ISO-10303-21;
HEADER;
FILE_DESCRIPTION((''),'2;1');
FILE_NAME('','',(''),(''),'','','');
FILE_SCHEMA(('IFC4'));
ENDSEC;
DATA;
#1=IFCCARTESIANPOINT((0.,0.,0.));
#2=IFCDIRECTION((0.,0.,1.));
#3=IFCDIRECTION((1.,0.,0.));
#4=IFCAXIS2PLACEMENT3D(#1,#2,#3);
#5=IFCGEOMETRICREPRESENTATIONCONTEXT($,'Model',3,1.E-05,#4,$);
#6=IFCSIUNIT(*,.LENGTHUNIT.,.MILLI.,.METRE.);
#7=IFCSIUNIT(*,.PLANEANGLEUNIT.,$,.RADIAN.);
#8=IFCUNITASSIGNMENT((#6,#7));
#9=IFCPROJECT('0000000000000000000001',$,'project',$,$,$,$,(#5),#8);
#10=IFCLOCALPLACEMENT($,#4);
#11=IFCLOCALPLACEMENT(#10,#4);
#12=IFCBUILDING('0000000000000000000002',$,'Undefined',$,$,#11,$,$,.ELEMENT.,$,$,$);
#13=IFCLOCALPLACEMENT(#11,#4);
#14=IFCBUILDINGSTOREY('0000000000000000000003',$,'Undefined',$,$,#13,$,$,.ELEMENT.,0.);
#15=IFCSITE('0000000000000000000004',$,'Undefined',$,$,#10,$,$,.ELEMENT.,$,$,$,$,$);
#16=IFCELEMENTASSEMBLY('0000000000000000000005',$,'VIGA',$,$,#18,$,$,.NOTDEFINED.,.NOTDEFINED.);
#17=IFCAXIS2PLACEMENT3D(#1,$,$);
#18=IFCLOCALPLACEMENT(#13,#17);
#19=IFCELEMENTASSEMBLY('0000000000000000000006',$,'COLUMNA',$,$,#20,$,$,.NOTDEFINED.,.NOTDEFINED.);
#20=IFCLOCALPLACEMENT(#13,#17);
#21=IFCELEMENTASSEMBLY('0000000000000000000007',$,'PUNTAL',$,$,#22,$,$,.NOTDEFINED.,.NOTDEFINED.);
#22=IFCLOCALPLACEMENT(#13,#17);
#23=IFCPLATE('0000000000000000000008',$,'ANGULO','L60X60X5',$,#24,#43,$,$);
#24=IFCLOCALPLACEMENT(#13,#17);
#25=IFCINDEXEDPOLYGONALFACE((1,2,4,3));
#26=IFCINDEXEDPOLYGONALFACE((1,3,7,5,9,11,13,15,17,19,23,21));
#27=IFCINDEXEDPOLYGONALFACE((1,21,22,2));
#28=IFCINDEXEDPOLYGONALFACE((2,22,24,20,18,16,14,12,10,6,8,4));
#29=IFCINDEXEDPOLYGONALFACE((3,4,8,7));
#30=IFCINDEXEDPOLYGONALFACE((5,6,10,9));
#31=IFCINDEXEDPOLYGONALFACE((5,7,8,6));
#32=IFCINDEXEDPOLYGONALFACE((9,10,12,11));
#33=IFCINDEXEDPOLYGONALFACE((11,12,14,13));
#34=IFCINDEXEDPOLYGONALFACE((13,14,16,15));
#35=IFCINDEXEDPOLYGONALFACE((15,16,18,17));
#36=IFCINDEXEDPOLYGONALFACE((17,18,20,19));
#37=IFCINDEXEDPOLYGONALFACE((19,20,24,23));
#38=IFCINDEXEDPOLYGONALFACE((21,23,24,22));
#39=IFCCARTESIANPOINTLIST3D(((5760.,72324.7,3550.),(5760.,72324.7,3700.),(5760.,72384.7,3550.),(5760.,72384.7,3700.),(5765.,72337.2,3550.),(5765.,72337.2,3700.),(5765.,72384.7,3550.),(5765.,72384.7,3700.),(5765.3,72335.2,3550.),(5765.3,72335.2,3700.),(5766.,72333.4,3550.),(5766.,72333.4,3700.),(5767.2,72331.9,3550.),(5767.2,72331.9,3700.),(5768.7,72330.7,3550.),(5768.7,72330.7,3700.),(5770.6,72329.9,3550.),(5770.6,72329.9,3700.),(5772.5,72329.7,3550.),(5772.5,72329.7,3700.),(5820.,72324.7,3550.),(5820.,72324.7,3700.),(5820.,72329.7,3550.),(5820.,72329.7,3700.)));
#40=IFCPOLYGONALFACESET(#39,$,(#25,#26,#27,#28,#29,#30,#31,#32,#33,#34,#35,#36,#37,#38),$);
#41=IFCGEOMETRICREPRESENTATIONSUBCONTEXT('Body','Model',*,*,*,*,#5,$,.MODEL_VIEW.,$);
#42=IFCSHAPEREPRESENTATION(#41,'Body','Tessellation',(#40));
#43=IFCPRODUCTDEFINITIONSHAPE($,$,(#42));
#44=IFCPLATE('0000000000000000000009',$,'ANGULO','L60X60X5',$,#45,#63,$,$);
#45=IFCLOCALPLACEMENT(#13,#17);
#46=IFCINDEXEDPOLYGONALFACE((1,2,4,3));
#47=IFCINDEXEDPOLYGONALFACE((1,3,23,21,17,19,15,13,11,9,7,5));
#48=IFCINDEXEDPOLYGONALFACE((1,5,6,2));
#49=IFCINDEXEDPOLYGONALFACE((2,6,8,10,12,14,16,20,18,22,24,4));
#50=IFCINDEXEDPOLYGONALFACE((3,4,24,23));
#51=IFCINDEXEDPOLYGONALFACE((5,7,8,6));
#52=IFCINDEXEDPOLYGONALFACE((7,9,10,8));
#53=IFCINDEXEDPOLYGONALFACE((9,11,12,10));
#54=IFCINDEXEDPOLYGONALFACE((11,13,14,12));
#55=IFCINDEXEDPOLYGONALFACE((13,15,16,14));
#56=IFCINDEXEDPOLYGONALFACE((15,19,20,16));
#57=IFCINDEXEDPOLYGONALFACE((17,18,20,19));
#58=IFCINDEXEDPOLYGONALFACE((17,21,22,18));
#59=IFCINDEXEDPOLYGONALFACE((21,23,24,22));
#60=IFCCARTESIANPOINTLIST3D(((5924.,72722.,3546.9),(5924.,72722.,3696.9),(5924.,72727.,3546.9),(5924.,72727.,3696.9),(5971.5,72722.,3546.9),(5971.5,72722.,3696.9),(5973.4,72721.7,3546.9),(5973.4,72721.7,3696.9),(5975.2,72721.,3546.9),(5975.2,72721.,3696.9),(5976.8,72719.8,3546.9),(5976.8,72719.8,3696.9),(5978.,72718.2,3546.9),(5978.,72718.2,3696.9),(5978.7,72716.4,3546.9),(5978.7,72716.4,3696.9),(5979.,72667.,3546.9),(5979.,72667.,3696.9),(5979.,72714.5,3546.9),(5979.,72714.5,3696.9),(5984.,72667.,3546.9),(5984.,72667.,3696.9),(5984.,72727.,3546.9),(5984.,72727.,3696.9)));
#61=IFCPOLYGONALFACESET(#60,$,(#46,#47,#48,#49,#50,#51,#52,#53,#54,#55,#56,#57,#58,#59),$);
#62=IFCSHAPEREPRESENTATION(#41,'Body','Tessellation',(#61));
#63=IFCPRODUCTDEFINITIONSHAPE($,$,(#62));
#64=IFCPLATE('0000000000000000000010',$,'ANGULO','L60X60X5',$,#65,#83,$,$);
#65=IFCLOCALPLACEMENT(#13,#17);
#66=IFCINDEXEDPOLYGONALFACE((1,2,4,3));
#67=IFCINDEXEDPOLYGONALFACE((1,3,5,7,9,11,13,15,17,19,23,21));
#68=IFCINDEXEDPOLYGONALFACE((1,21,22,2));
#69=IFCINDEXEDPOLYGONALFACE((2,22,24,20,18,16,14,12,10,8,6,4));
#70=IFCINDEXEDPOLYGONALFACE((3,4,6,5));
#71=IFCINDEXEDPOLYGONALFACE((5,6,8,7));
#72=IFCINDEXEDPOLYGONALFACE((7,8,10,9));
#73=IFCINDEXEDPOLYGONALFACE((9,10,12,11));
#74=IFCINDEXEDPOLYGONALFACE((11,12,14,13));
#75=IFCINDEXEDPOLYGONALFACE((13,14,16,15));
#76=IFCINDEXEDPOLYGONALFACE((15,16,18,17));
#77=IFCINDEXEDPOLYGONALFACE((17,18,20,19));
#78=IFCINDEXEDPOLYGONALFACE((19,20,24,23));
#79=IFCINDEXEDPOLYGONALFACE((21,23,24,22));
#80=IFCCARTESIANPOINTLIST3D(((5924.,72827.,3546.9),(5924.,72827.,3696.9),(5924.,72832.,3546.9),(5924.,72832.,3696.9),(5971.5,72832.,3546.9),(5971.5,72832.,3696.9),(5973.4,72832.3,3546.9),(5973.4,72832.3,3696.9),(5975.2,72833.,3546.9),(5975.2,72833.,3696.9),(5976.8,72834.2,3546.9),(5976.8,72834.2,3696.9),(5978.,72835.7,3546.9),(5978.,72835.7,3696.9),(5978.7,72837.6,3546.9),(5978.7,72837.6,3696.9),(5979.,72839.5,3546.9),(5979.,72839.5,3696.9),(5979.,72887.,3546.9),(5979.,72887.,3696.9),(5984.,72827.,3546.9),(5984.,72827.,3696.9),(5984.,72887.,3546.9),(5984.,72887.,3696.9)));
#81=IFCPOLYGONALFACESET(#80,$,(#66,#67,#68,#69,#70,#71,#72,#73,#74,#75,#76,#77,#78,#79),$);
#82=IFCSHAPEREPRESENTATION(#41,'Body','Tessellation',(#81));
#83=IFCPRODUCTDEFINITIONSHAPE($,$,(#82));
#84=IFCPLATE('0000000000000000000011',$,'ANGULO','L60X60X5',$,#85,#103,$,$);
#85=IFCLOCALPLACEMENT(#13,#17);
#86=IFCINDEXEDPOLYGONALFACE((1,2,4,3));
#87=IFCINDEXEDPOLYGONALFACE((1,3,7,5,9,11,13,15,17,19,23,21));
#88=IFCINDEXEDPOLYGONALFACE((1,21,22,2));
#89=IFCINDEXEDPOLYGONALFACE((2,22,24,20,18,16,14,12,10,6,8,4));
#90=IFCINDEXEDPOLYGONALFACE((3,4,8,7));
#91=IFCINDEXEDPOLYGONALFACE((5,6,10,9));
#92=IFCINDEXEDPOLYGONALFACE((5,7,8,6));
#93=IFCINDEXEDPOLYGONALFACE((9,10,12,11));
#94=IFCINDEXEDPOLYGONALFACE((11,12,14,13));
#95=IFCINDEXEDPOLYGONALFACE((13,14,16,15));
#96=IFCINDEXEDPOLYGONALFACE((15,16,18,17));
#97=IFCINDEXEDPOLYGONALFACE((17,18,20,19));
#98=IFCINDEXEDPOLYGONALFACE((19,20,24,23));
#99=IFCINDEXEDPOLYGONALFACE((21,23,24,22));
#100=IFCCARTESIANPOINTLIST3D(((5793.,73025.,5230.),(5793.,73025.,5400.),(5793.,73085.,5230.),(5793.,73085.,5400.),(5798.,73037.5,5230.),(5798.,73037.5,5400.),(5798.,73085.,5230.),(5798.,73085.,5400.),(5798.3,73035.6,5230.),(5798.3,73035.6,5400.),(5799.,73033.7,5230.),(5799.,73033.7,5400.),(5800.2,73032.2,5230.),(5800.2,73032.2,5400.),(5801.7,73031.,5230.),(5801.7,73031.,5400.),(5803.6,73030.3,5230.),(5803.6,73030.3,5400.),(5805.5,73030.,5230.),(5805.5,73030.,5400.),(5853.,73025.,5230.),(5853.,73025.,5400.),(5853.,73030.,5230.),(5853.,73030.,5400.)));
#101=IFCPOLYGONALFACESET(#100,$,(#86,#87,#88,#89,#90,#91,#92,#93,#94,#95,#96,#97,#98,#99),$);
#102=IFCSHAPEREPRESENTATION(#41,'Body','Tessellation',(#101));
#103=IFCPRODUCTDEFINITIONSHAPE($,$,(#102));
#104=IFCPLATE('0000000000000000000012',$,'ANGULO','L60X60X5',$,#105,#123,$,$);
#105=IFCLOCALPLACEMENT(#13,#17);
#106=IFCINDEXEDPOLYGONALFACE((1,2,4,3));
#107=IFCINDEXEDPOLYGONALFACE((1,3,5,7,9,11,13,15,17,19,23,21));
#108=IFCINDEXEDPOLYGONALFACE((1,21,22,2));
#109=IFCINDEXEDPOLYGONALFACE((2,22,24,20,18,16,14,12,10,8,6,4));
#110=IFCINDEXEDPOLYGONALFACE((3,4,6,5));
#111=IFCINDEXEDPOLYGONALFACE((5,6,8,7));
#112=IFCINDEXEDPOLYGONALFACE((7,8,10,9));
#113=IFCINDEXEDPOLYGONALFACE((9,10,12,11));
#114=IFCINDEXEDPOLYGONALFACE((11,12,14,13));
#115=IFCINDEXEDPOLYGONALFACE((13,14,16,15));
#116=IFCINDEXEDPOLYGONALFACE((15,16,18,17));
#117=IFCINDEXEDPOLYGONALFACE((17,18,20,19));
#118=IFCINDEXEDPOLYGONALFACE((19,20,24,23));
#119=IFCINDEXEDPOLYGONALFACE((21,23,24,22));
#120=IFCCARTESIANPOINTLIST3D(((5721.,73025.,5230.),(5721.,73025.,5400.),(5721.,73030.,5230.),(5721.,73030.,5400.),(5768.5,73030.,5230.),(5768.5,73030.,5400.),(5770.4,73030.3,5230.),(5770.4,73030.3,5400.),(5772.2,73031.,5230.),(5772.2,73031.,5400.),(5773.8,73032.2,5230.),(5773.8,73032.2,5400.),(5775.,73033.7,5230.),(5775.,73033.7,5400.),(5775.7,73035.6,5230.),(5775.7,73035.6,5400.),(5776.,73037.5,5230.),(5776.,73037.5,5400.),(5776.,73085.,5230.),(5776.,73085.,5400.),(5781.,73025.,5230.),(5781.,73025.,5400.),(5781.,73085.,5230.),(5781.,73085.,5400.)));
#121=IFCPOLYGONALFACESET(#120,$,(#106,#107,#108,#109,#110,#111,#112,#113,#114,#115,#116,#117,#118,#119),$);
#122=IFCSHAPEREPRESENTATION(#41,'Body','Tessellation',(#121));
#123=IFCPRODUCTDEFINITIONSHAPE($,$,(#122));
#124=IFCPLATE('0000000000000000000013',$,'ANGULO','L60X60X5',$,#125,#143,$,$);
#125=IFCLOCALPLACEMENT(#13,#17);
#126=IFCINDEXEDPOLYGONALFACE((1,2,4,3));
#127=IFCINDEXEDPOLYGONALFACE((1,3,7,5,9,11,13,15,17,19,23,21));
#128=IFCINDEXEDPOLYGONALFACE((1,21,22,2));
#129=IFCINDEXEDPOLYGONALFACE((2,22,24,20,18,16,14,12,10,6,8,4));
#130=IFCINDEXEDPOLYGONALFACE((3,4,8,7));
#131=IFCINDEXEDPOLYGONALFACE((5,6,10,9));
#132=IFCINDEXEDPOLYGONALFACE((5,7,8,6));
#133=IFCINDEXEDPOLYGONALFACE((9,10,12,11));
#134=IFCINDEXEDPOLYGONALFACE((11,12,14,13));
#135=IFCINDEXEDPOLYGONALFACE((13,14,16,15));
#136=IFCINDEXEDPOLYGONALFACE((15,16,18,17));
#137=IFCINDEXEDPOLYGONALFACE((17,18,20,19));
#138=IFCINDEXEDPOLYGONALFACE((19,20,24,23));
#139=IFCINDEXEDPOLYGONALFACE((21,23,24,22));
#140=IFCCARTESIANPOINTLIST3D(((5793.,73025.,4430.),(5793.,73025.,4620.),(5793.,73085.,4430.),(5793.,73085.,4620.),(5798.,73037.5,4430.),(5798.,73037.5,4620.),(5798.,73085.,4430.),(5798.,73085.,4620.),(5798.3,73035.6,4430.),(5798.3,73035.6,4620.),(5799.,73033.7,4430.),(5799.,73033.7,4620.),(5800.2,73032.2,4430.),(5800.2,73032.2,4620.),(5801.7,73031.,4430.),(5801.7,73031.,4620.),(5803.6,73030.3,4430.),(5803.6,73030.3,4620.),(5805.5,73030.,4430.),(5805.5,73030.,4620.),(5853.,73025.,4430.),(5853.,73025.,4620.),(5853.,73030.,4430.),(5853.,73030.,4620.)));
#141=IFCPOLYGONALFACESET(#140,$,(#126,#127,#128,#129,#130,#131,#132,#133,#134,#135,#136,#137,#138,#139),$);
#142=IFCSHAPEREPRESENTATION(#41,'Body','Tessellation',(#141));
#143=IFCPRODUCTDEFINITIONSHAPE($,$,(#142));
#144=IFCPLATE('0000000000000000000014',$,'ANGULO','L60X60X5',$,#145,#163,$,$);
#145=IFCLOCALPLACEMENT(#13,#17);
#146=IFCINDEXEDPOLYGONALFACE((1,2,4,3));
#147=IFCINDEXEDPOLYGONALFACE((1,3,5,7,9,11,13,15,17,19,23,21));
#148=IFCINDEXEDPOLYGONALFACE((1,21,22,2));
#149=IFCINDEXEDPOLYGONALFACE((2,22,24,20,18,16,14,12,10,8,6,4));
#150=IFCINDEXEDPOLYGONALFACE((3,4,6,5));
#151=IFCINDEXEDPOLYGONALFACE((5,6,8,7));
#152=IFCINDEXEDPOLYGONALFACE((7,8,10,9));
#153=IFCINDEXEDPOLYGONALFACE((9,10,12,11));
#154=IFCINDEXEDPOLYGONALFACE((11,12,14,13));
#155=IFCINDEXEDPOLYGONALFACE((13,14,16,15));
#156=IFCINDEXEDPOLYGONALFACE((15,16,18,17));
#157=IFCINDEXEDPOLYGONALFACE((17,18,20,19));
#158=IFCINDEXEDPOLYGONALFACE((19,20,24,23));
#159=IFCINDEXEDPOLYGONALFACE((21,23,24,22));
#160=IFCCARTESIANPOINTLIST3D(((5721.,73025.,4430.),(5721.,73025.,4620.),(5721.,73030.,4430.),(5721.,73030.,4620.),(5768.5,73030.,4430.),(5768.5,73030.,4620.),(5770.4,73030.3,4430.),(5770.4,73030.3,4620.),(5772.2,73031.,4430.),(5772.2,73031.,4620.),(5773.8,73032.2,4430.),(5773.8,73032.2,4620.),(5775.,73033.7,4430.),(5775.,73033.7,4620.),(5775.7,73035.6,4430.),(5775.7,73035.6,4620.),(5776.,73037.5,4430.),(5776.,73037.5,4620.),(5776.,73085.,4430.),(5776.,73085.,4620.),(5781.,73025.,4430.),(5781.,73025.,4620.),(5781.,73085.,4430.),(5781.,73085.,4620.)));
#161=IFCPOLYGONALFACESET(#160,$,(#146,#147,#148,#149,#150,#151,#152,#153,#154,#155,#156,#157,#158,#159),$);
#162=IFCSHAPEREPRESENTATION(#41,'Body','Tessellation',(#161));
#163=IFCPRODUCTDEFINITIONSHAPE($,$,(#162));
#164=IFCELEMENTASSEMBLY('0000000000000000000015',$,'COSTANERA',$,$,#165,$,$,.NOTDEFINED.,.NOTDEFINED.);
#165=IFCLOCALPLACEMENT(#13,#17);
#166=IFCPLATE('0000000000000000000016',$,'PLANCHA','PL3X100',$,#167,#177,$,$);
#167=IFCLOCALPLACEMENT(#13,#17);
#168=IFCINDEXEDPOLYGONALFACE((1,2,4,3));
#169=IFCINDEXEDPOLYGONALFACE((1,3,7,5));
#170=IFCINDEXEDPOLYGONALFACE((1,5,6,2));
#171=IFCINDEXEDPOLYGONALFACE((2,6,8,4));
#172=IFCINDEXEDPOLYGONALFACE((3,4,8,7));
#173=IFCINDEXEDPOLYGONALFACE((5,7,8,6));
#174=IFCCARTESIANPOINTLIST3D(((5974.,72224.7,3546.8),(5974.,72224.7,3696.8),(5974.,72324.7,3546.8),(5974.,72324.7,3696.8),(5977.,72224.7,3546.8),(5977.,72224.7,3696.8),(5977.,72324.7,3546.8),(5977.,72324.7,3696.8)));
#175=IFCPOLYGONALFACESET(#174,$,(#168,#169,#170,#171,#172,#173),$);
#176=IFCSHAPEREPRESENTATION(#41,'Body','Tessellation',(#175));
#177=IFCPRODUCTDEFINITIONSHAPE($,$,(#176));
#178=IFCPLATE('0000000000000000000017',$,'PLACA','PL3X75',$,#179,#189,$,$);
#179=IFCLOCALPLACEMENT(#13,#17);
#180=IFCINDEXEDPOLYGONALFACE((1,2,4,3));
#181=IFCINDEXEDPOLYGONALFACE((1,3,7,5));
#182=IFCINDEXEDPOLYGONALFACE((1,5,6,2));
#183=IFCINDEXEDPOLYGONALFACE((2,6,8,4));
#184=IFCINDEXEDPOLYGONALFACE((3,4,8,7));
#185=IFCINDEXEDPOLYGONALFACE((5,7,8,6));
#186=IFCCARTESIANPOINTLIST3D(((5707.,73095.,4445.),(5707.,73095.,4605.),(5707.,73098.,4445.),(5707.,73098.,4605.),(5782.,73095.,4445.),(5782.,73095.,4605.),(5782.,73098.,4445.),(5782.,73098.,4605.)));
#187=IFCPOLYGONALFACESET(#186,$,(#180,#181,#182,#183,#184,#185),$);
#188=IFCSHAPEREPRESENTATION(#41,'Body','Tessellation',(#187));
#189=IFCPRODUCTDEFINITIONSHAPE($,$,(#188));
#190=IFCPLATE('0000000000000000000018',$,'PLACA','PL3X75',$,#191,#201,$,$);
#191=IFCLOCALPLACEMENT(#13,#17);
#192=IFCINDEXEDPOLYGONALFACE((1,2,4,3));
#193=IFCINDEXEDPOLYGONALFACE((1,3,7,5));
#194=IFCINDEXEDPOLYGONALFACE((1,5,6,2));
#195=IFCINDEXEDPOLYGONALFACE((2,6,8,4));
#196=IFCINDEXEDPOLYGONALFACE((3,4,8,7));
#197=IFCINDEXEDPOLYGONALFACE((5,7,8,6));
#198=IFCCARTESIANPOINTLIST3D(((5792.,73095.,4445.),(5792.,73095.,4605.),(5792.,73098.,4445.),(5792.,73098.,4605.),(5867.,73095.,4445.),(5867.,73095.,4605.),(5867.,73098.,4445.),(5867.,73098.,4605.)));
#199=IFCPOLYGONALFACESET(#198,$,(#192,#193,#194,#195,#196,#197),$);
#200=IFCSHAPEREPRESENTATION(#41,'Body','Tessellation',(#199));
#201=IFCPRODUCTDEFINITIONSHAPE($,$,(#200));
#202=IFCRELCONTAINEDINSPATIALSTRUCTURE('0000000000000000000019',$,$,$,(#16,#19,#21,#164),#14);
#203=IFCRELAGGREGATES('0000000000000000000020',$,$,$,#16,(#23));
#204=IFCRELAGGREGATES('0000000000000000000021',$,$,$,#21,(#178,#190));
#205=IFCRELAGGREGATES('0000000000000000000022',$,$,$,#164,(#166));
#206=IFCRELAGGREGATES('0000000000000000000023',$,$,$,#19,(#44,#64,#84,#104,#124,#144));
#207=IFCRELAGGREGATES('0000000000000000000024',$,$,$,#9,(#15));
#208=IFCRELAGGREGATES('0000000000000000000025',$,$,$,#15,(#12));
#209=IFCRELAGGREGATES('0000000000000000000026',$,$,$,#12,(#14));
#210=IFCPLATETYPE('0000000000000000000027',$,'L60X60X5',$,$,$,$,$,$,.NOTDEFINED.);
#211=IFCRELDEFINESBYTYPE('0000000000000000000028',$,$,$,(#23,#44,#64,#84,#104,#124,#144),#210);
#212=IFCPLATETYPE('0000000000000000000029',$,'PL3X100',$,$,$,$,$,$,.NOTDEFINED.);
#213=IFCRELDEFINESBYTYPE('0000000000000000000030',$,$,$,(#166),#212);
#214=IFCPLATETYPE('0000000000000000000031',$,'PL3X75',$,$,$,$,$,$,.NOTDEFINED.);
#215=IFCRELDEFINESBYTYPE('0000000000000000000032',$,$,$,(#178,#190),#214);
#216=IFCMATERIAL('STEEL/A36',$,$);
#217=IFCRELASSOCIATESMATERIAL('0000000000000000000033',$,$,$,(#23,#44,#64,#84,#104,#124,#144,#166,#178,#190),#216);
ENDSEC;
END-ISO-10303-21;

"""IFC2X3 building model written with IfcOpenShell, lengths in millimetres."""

from ifc_helpers import new_model, si_unit, frame, origin_with_axes, origin_2d_with_axis, place, context, subcontext, project, spatial, polyline, l_section, outline, extrude, material, type_object, element, aggregate, save


model = new_model("IFC2X3")

# Units and contexts
model_context = context("Model", 3, precision=1e-05, world=origin_with_axes())
body_context = subcontext(model_context, "Body", "Model", "MODEL_VIEW")
ifc_project = project(units=[si_unit("LENGTHUNIT", "METRE", prefix="MILLI"), si_unit("PLANEANGLEUNIT", "RADIAN")], contexts=[model_context])

# Site, building, storey
site_placement = place(None, origin_with_axes())
site = spatial("IfcSite", under=ifc_project, at=site_placement, Name="Undefined", CompositionType="ELEMENT")
building_placement = place(site_placement, origin_with_axes())
building = spatial("IfcBuilding", under=site, at=building_placement, Name="Undefined", CompositionType="ELEMENT")
storey_placement = place(building_placement, origin_with_axes())
storey = spatial("IfcBuildingStorey", under=building, at=storey_placement, Name="Undefined", CompositionType="ELEMENT", Elevation=0.0)

# Element assemblies
assembly_1_placement = place(storey_placement, origin_with_axes())
assembly_1 = element("IfcElementAssembly", 1, at=assembly_1_placement, inside=storey, Name="VIGA", AssemblyPlace="NOTDEFINED", PredefinedType="NOTDEFINED")
ifc_material_1 = material(Name="STEEL/A36")
assembly_2_placement = place(storey_placement, origin_with_axes())
assembly_2 = element("IfcElementAssembly", 2, at=assembly_2_placement, inside=storey, Name="COLUMNA", AssemblyPlace="NOTDEFINED", PredefinedType="NOTDEFINED")
assembly_3_placement = place(storey_placement, origin_with_axes())
assembly_3 = element("IfcElementAssembly", 3, at=assembly_3_placement, inside=storey, Name="PUNTAL", AssemblyPlace="NOTDEFINED", PredefinedType="NOTDEFINED")

# Plates
plate_type_1 = type_object("IfcPlateType", Name="L60X60X5", PredefinedType="NOTDEFINED")
plate_1_placement = place(assembly_1_placement, frame((5790.0, 72354.7, 3700.0), z_axis=(0.0, 1.0, 0.0), x_axis=(0.0, 0.0, -1.0)))
plate_1 = element("IfcPlate", 4, at=plate_1_placement, type_object=plate_type_1, material=ifc_material_1, Name="ANGULO", Description="L60X60X5", context=body_context, shape_type="SweptSolid", body=[
    extrude(l_section(Depth=60.0, Width=60.0, Thickness=5.0, FilletRadius=7.5, at=origin_2d_with_axis()), frame((150.0, 0.0, 0.0), z_axis=(-1.0, 0.0, 0.0), x_axis=(0.0, -1.0, 0.0)), (0.0, 0.0, 1.0), 150.0),
])
aggregate(assembly_1, [plate_1])
plate_2_placement = place(assembly_2_placement, frame((5954.0, 72697.0, 3546.9), z_axis=(-1.0, 0.0, 0.0), x_axis=(0.0, 0.0, 1.0)))
plate_2 = element("IfcPlate", 5, at=plate_2_placement, type_object=plate_type_1, material=ifc_material_1, Name="ANGULO", Description="L60X60X5", context=body_context, shape_type="SweptSolid", body=[
    extrude(l_section(Depth=60.0, Width=60.0, Thickness=5.0, FilletRadius=7.5, at=origin_2d_with_axis()), frame((150.0, 0.0, 0.0), z_axis=(-1.0, 0.0, 0.0), x_axis=(0.0, -1.0, 0.0)), (0.0, 0.0, 1.0), 150.0),
])
plate_3_placement = place(assembly_2_placement, frame((5954.0, 72857.0, 3696.9), z_axis=(-1.0, 0.0, 0.0), x_axis=(0.0, 0.0, -1.0)))
plate_3 = element("IfcPlate", 6, at=plate_3_placement, type_object=plate_type_1, material=ifc_material_1, Name="ANGULO", Description="L60X60X5", context=body_context, shape_type="SweptSolid", body=[
    extrude(l_section(Depth=60.0, Width=60.0, Thickness=5.0, FilletRadius=7.5, at=origin_2d_with_axis()), frame((150.0, 0.0, 0.0), z_axis=(-1.0, 0.0, 0.0), x_axis=(0.0, -1.0, 0.0)), (0.0, 0.0, 1.0), 150.0),
])
plate_4_placement = place(assembly_2_placement, frame((5823.0, 73055.0, 5230.0), z_axis=(1.0, 0.0, 0.0), x_axis=(0.0, 0.0, 1.0)))
plate_4 = element("IfcPlate", 7, at=plate_4_placement, type_object=plate_type_1, material=ifc_material_1, Name="ANGULO", Description="L60X60X5", context=body_context, shape_type="SweptSolid", body=[
    extrude(l_section(Depth=60.0, Width=60.0, Thickness=5.0, FilletRadius=7.5, at=origin_2d_with_axis()), frame((170.0, 0.0, 0.0), z_axis=(-1.0, 0.0, 0.0), x_axis=(0.0, -1.0, 0.0)), (0.0, 0.0, 1.0), 170.0),
])
plate_5_placement = place(assembly_2_placement, frame((5751.0, 73055.0, 5400.0), z_axis=(-1.0, 0.0, 0.0), x_axis=(0.0, 0.0, -1.0)))
plate_5 = element("IfcPlate", 8, at=plate_5_placement, type_object=plate_type_1, material=ifc_material_1, Name="ANGULO", Description="L60X60X5", context=body_context, shape_type="SweptSolid", body=[
    extrude(l_section(Depth=60.0, Width=60.0, Thickness=5.0, FilletRadius=7.5, at=origin_2d_with_axis()), frame((170.0, 0.0, 0.0), z_axis=(-1.0, 0.0, 0.0), x_axis=(0.0, -1.0, 0.0)), (0.0, 0.0, 1.0), 170.0),
])
plate_6_placement = place(assembly_2_placement, frame((5823.0, 73055.0, 4430.0), z_axis=(1.0, 0.0, 0.0), x_axis=(0.0, 0.0, 1.0)))
plate_6 = element("IfcPlate", 9, at=plate_6_placement, type_object=plate_type_1, material=ifc_material_1, Name="ANGULO", Description="L60X60X5", context=body_context, shape_type="SweptSolid", body=[
    extrude(l_section(Depth=60.0, Width=60.0, Thickness=5.0, FilletRadius=7.5, at=origin_2d_with_axis()), frame((190.0, 0.0, 0.0), z_axis=(-1.0, 0.0, 0.0), x_axis=(0.0, -1.0, 0.0)), (0.0, 0.0, 1.0), 190.0),
])
plate_7_placement = place(assembly_2_placement, frame((5751.0, 73055.0, 4620.0), z_axis=(-1.0, 0.0, 0.0), x_axis=(0.0, 0.0, -1.0)))
plate_7 = element("IfcPlate", 10, at=plate_7_placement, type_object=plate_type_1, material=ifc_material_1, Name="ANGULO", Description="L60X60X5", context=body_context, shape_type="SweptSolid", body=[
    extrude(l_section(Depth=60.0, Width=60.0, Thickness=5.0, FilletRadius=7.5, at=origin_2d_with_axis()), frame((190.0, 0.0, 0.0), z_axis=(-1.0, 0.0, 0.0), x_axis=(0.0, -1.0, 0.0)), (0.0, 0.0, 1.0), 190.0),
])

# Element assembly, plate
assembly_4_placement = place(storey_placement, origin_with_axes())
assembly_4 = element("IfcElementAssembly", 11, at=assembly_4_placement, inside=storey, Name="COSTANERA", AssemblyPlace="NOTDEFINED", PredefinedType="NOTDEFINED")
plate_type_2 = type_object("IfcPlateType", Name="PL3X100", PredefinedType="NOTDEFINED")
plate_8_placement = place(assembly_4_placement, frame((5975.5, 72324.7, 3546.8), z_axis=(-1.0, 0.0, 0.0), x_axis=(0.0, -1.0, 0.0)))
plate_8 = element("IfcPlate", 12, at=plate_8_placement, type_object=plate_type_2, material=ifc_material_1, Name="PLANCHA", Description="PL3X100", context=body_context, shape_type="SweptSolid", body=[
    extrude(outline(polyline([(0.0, 0.0), (100.0, 0.0), (100.0, 150.0), (0.0, 150.0), (0.0, 0.0)])), frame((0.0, 0.0, -1.5), z_axis=(0.0, 0.0, 1.0), x_axis=(1.0, 0.0, 0.0)), (0.0, 0.0, 1.0), 3.0),
])

# Plates
plate_type_3 = type_object("IfcPlateType", Name="PL3X75", PredefinedType="NOTDEFINED")
plate_9_placement = place(assembly_3_placement, frame((5707.0, 73096.5, 4605.0), z_axis=(0.0, 1.0, 0.0), x_axis=(1.0, 0.0, 0.0)))
plate_9 = element("IfcPlate", 13, at=plate_9_placement, type_object=plate_type_3, material=ifc_material_1, Name="PLACA", Description="PL3X75", context=body_context, shape_type="SweptSolid", body=[
    extrude(outline(polyline([(0.0, 0.0), (75.0, 0.0), (75.0, 160.0), (0.0, 160.0), (0.0, 0.0)])), frame((0.0, 0.0, -1.5), z_axis=(0.0, 0.0, 1.0), x_axis=(1.0, 0.0, 0.0)), (0.0, 0.0, 1.0), 3.0),
])
plate_10_placement = place(assembly_3_placement, frame((5792.0, 73096.5, 4605.0), z_axis=(0.0, 1.0, 0.0), x_axis=(1.0, 0.0, 0.0)))
plate_10 = element("IfcPlate", 14, at=plate_10_placement, type_object=plate_type_3, material=ifc_material_1, Name="PLACA", Description="PL3X75", context=body_context, shape_type="SweptSolid", body=[
    extrude(outline(polyline([(0.0, 0.0), (75.0, 0.0), (75.0, 160.0), (0.0, 160.0), (0.0, 0.0)])), frame((0.0, 0.0, -1.5), z_axis=(0.0, 0.0, 1.0), x_axis=(1.0, 0.0, 0.0)), (0.0, 0.0, 1.0), 3.0),
])
aggregate(assembly_3, [plate_9, plate_10])

aggregate(assembly_4, [plate_8])

aggregate(assembly_2, [plate_2, plate_3, plate_4, plate_5, plate_6, plate_7])

save(model, "model.ifc")
